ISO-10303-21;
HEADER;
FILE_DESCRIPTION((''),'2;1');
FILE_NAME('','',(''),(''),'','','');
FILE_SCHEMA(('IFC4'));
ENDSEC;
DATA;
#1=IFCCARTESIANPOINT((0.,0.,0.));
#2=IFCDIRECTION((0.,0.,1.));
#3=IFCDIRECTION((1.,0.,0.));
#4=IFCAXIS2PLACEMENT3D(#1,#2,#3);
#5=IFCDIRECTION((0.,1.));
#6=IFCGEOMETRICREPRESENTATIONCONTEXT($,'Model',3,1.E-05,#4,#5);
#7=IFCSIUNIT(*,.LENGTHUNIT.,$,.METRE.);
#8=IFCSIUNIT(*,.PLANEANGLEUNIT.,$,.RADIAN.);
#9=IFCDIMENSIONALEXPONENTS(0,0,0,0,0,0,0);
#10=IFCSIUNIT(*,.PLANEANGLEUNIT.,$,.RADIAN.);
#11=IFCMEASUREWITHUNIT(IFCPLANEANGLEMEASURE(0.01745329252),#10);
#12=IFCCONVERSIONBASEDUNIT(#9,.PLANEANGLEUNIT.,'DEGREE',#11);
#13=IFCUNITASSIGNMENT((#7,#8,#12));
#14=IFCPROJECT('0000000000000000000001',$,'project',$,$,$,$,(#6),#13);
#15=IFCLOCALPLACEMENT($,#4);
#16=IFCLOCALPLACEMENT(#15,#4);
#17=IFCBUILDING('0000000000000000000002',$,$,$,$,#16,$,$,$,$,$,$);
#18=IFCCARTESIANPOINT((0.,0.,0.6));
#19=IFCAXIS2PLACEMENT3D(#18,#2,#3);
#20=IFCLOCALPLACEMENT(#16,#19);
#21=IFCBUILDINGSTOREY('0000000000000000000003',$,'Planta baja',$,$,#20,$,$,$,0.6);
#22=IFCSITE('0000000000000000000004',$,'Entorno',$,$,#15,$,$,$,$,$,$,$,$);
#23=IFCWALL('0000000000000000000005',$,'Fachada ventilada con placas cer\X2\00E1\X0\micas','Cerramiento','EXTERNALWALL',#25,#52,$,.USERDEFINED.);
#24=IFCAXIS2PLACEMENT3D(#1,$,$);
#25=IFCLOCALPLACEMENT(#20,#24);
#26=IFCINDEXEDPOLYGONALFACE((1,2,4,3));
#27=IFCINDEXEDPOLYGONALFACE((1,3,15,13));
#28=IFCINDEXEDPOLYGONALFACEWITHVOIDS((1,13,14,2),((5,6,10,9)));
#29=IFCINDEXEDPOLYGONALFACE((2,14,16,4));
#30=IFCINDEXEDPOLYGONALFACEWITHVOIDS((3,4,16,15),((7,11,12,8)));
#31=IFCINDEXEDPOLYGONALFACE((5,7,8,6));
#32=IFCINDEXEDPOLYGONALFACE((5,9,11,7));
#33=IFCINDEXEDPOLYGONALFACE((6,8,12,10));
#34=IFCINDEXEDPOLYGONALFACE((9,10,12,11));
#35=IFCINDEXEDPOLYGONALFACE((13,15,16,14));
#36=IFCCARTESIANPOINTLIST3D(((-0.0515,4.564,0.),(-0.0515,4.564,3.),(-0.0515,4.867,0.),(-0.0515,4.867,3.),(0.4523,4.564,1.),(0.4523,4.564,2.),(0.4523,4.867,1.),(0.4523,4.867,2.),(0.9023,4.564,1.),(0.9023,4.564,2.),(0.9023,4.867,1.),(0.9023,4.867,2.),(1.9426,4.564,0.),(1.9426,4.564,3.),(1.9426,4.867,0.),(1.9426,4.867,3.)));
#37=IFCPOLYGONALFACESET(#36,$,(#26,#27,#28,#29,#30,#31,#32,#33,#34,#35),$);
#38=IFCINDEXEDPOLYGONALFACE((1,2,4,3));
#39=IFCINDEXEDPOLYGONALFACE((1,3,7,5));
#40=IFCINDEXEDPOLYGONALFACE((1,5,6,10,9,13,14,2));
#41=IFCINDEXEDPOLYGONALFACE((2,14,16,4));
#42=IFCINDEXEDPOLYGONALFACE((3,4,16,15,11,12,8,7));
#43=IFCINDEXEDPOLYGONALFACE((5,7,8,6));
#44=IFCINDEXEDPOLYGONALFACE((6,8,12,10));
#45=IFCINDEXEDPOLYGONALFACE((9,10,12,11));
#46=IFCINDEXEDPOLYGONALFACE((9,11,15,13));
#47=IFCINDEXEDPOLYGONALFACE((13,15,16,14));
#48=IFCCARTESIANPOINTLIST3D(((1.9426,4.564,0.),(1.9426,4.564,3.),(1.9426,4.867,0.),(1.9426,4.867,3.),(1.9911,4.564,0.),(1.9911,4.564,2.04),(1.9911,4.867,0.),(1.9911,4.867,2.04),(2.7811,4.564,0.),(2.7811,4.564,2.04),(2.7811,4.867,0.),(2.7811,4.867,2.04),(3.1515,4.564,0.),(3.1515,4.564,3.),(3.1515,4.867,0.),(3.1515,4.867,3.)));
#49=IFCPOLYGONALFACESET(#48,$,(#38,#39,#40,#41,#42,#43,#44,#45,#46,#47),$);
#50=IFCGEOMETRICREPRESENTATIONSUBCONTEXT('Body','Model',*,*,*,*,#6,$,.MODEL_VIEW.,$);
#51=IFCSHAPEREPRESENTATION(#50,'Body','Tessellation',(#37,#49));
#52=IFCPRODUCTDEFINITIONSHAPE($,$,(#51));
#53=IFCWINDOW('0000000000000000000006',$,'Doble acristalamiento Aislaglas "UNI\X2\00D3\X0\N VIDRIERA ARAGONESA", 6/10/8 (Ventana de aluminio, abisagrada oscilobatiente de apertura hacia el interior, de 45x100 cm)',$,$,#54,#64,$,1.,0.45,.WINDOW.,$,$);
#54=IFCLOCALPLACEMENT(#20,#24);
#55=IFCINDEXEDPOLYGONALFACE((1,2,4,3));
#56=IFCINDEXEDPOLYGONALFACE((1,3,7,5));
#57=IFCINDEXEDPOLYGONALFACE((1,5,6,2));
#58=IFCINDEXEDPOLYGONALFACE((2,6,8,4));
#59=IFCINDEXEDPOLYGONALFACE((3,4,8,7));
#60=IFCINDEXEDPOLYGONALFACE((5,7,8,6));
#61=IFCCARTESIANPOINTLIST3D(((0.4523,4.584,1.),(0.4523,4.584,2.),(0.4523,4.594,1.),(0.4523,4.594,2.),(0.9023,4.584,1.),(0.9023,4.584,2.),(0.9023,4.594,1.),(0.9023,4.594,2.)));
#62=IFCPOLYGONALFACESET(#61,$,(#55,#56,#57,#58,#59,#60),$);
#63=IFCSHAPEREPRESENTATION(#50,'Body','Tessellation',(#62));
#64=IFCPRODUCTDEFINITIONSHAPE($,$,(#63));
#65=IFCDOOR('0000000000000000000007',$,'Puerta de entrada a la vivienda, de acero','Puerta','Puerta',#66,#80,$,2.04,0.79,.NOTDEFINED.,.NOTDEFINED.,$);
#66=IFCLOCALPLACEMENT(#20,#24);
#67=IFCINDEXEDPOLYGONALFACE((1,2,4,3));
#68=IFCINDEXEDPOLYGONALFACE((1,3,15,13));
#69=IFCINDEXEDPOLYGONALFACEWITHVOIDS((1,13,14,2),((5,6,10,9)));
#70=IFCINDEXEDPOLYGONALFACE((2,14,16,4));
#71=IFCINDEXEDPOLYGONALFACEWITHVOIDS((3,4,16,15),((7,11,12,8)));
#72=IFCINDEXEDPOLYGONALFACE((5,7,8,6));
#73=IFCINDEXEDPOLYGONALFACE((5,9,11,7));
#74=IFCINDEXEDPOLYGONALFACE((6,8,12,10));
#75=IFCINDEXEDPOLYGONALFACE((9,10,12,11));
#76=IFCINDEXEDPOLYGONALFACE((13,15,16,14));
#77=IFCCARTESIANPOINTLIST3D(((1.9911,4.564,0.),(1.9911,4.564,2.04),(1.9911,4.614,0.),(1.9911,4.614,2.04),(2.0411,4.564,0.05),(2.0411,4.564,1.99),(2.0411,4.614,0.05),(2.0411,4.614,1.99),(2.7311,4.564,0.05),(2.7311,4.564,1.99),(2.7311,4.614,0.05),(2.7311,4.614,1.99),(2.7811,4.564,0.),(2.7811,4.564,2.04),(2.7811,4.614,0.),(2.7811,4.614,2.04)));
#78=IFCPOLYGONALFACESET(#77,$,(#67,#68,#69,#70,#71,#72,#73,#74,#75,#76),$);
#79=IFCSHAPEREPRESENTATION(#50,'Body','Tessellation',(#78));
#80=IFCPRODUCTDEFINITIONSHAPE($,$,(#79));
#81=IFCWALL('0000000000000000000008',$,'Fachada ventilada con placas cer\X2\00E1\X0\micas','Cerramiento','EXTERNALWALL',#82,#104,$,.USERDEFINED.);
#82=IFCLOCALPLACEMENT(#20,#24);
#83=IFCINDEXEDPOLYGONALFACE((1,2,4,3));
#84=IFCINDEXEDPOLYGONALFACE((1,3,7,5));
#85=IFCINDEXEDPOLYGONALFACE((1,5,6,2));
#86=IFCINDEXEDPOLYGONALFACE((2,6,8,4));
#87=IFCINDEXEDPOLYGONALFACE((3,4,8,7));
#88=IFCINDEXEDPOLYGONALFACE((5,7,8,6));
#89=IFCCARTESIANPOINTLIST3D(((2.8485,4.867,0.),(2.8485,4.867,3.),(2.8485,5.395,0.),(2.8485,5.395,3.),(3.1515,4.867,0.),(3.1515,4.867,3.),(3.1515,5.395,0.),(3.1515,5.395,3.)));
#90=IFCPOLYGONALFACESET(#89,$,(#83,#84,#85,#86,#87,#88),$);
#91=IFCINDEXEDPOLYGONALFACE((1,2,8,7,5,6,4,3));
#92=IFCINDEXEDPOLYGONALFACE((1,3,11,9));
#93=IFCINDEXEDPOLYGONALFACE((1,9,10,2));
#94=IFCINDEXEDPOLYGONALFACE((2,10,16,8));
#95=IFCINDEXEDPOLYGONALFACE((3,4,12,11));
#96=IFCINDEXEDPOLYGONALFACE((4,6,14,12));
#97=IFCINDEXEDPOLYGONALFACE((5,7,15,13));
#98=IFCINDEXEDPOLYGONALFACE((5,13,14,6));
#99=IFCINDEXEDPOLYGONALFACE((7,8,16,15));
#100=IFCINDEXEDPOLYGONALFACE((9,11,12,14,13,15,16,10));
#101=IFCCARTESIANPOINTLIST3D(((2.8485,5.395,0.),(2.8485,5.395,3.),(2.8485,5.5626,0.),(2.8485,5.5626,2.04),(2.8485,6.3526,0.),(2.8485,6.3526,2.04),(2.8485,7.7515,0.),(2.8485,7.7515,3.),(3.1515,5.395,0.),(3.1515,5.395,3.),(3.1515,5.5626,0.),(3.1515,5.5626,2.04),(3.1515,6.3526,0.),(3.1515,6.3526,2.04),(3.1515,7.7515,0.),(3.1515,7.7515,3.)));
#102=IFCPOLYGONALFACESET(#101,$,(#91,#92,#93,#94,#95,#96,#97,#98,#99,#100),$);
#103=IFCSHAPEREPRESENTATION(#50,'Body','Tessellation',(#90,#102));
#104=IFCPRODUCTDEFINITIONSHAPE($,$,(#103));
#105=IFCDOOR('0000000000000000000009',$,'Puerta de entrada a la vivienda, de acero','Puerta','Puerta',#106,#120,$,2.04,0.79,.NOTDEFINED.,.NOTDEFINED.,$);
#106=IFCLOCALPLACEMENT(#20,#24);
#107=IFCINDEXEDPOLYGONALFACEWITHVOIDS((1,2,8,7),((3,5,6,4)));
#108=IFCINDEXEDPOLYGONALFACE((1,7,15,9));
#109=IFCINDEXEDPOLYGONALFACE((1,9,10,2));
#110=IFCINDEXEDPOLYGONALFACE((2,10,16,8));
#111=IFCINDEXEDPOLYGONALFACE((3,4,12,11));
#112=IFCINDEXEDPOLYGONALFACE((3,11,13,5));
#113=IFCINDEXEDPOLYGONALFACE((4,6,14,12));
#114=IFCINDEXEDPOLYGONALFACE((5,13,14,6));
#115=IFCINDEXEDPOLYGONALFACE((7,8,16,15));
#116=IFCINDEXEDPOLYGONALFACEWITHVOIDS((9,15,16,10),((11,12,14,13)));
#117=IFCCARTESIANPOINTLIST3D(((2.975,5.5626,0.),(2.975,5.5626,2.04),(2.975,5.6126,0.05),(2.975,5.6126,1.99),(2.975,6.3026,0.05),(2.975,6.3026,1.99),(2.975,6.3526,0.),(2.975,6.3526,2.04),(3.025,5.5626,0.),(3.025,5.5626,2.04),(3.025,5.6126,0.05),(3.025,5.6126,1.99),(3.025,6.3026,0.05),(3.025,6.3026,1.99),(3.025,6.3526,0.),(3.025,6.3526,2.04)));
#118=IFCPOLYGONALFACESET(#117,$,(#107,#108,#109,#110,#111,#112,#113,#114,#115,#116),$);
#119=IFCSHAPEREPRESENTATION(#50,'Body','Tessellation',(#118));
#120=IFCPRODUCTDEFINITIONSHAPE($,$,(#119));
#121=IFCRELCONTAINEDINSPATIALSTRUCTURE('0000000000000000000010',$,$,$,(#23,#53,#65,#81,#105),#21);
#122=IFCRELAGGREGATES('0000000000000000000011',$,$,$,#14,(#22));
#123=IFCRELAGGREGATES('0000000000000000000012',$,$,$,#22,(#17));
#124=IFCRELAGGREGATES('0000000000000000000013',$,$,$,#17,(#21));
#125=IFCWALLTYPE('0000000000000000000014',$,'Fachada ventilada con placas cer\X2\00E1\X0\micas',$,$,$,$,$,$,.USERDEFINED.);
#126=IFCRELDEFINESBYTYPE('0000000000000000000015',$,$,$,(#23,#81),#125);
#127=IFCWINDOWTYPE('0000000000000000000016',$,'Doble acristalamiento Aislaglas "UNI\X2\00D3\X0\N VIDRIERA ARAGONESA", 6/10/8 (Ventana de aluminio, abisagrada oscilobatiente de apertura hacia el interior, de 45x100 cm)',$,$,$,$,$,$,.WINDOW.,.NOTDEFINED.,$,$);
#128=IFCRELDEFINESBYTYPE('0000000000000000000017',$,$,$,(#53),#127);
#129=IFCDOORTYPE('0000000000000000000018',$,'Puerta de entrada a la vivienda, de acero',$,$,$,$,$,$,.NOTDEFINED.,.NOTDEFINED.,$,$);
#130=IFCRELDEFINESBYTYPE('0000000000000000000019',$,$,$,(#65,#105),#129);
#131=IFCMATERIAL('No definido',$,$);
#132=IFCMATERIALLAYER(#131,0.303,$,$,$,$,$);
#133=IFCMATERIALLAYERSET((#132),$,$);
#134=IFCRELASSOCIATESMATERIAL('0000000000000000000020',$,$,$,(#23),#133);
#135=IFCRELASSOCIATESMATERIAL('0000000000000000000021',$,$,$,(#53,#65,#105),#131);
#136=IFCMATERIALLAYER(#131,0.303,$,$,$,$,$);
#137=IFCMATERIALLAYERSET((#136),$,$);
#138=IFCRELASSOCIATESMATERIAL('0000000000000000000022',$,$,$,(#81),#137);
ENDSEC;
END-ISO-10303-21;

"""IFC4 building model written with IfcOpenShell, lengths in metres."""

from ifc_helpers import new_model, entity, si_unit, converted_unit, direction, frame, origin_with_axes, origin_2d_with_axis, place, context, subcontext, project, spatial, rectangle, hollow_rectangle, extrude, shape, material, layer, layer_set, layer_usage, type_object, element, fill, save


model = new_model("IFC4")

# Units and contexts
model_context = context("Model", 3, precision=1e-05, world=origin_with_axes(), true_north=direction((0.0, 1.0)))
body_context = subcontext(model_context, "Body", "Model", "MODEL_VIEW")
footprint_context = subcontext(model_context, "FootPrint", "Model", "MODEL_VIEW")
ifc_project = project(units=[si_unit("LENGTHUNIT", "METRE"), si_unit("PLANEANGLEUNIT", "RADIAN"), converted_unit("PLANEANGLEUNIT", "DEGREE", entity("IfcPlaneAngleMeasure", 0.01745329252), si_unit("PLANEANGLEUNIT", "RADIAN"), dimensions=[0, 0, 0, 0, 0, 0, 0])], contexts=[model_context])

# Site, building, storey
site_placement = place(None, origin_with_axes())
site = spatial("IfcSite", under=ifc_project, at=site_placement, Name="Entorno")
building_placement = place(site_placement, origin_with_axes())
building = spatial("IfcBuilding", under=site, at=building_placement)
storey_placement = place(building_placement, frame((0.0, 0.0, 0.6), z_axis=(0.0, 0.0, 1.0), x_axis=(1.0, 0.0, 0.0)))
storey = spatial("IfcBuildingStorey", under=building, at=storey_placement, Name="Planta baja", Elevation=0.6)

# Shared definitions
ifc_material = material(Name="No definido")

# Shared definitions
wall_type_1 = type_object("IfcWallType", Name="Fachada ventilada con placas cerámicas", PredefinedType="USERDEFINED")

# Wall, openings, window, door
ifc_layer_1 = layer(ifc_material, 0.303)
ifc_layer_set_1 = layer_set([ifc_layer_1])
ifc_layer_usage_1 = layer_usage(ifc_layer_set_1, "AXIS2", "POSITIVE", -0.1515)
wall_1_placement = place(storey_placement, frame((0.1, 4.7155, 0.0), z_axis=(0.0, 0.0, 1.0), x_axis=(1.0, 0.0, 0.0)))
cartesian_point_1 = entity("IfcCartesianPoint", [-0.997, -1.5])
cartesian_point_2 = entity("IfcCartesianPoint", [-0.997, -1.5])
cartesian_point_3 = entity("IfcCartesianPoint", [-0.6045, -1.5])
cartesian_point_4 = entity("IfcCartesianPoint", [-0.6045, -1.5])
wall_1 = element("IfcWall", 1, at=wall_1_placement, inside=storey, type_object=wall_type_1, material=ifc_layer_usage_1, Name="Fachada ventilada con placas cerámicas", Description="Cerramiento", ObjectType="EXTERNALWALL", PredefinedType="USERDEFINED", context=body_context, shape_type="SolidModel", body=[
    entity("IfcExtrudedAreaSolidTapered", entity("IfcArbitraryClosedProfileDef", "AREA", None, entity("IfcPolyline", [cartesian_point_1, entity("IfcCartesianPoint", [0.997, -1.5]), entity("IfcCartesianPoint", [0.997, 1.5]), entity("IfcCartesianPoint", [-0.997, 1.5]), cartesian_point_1])), entity("IfcAxis2Placement3D", entity("IfcCartesianPoint", [0.8456, 0.1515, 1.5]), entity("IfcDirection", [0.0, -1.0, 0.0]), entity("IfcDirection", [1.0, 0.0, 0.0])), entity("IfcDirection", [0.0, 0.0, 1.0]), 0.303, entity("IfcArbitraryClosedProfileDef", "AREA", None, entity("IfcPolyline", [cartesian_point_2, entity("IfcCartesianPoint", [0.997, -1.5]), entity("IfcCartesianPoint", [0.997, 1.5]), entity("IfcCartesianPoint", [-0.997, 1.5]), cartesian_point_2]))),
    entity("IfcExtrudedAreaSolidTapered", entity("IfcArbitraryClosedProfileDef", "AREA", None, entity("IfcPolyline", [cartesian_point_3, entity("IfcCartesianPoint", [0.6045, -1.5]), entity("IfcCartesianPoint", [0.6045, 1.5]), entity("IfcCartesianPoint", [-0.6045, 1.5]), cartesian_point_3])), entity("IfcAxis2Placement3D", entity("IfcCartesianPoint", [2.447, 0.1515, 1.5]), entity("IfcDirection", [0.0, -1.0, 0.0]), entity("IfcDirection", [1.0, 0.0, 0.0])), entity("IfcDirection", [0.0, 0.0, 1.0]), 0.303, entity("IfcArbitraryClosedProfileDef", "AREA", None, entity("IfcPolyline", [cartesian_point_4, entity("IfcCartesianPoint", [0.6045, -1.5]), entity("IfcCartesianPoint", [0.6045, 1.5]), entity("IfcCartesianPoint", [-0.6045, 1.5]), cartesian_point_4]))),
])
opening_1_placement = place(wall_1_placement, frame((0.5773, 0.0, 1.5), z_axis=(0.0, 0.0, 1.0), x_axis=(1.0, 0.0, 0.0)))
cartesian_point_5 = entity("IfcCartesianPoint", [-0.225, -0.1515])
opening_1 = element("IfcOpeningElement", 2, at=opening_1_placement, cuts=wall_1, ObjectType="No definido", PredefinedType="OPENING", shapes=[
    shape(body_context, "Body", "SweptSolid", [extrude(rectangle(XDim=1.0, YDim=0.45, at=origin_2d_with_axis()), frame((0.0, -0.1515, 0.0), z_axis=(0.0, 1.0, 0.0), x_axis=(0.0, 0.0, 1.0)), (0.0, 0.0, 1.0), 0.303)]),
    shape(footprint_context, "FootPrint", "GeometricCurveSet", [entity("IfcGeometricCurveSet", [entity("IfcPolyline", [cartesian_point_5, entity("IfcCartesianPoint", [0.225, -0.1515]), entity("IfcCartesianPoint", [0.225, 0.1515]), entity("IfcCartesianPoint", [-0.225, 0.1515]), cartesian_point_5])])]),
])
opening_2_placement = place(wall_1_placement, frame((2.2861, 0.0, 1.02), z_axis=(0.0, 0.0, 1.0), x_axis=(1.0, 0.0, 0.0)))
cartesian_point_6 = entity("IfcCartesianPoint", [-0.395, -0.1515])
opening_2 = element("IfcOpeningElement", 3, at=opening_2_placement, cuts=wall_1, ObjectType="No definido", PredefinedType="OPENING", shapes=[
    shape(body_context, "Body", "SweptSolid", [extrude(rectangle(XDim=2.04, YDim=0.79, at=origin_2d_with_axis()), frame((0.0, -0.1515, 0.0), z_axis=(0.0, 1.0, 0.0), x_axis=(0.0, 0.0, 1.0)), (0.0, 0.0, 1.0), 0.303)]),
    shape(footprint_context, "FootPrint", "GeometricCurveSet", [entity("IfcGeometricCurveSet", [entity("IfcPolyline", [cartesian_point_6, entity("IfcCartesianPoint", [0.395, -0.1515]), entity("IfcCartesianPoint", [0.395, 0.1515]), entity("IfcCartesianPoint", [-0.395, 0.1515]), cartesian_point_6])])]),
])
window_type_1 = type_object("IfcWindowType", Name="Doble acristalamiento Aislaglas \"UNIÓN VIDRIERA ARAGONESA\", 6/10/8 (Ventana de aluminio, abisagrada oscilobatiente de apertura hacia el interior, de 45x100 cm)", PartitioningType="NOTDEFINED", PredefinedType="WINDOW")
window_1_placement = place(opening_1_placement, frame((0.0, -0.1265, 0.0), z_axis=(0.0, 0.0, 1.0), x_axis=(1.0, 0.0, 0.0)))
window_1 = element("IfcWindow", 4, at=window_1_placement, inside=storey, type_object=window_type_1, material=ifc_material, Name="Doble acristalamiento Aislaglas \"UNIÓN VIDRIERA ARAGONESA\", 6/10/8 (Ventana de aluminio, abisagrada oscilobatiente de apertura hacia el interior, de 45x100 cm)", OverallHeight=1.0, OverallWidth=0.45, PredefinedType="WINDOW", context=body_context, shape_type="SweptSolid", body=[
    extrude(rectangle(XDim=0.45, YDim=1.0, at=origin_2d_with_axis()), frame((0.0, 0.005, 0.0), z_axis=(0.0, -1.0, 0.0), x_axis=(1.0, 0.0, 0.0)), (0.0, 0.0, 1.0), 0.01),
])
fill(opening_1, window_1)
door_type_1 = type_object("IfcDoorType", Name="Puerta de entrada a la vivienda, de acero", OperationType="NOTDEFINED", PredefinedType="NOTDEFINED")
door_1_placement = place(opening_2_placement, frame((0.0, -0.1265, 0.0), z_axis=(0.0, 0.0, 1.0), x_axis=(1.0, 0.0, 0.0)))
door_1 = element("IfcDoor", 5, at=door_1_placement, inside=storey, type_object=door_type_1, material=ifc_material, Name="Puerta de entrada a la vivienda, de acero", Description="Puerta", ObjectType="Puerta", OperationType="NOTDEFINED", OverallHeight=2.04, OverallWidth=0.79, PredefinedType="NOTDEFINED", context=body_context, shape_type="SweptSolid", body=[
    extrude(hollow_rectangle(XDim=0.79, YDim=2.04, WallThickness=0.05, InnerFilletRadius=0.0, OuterFilletRadius=0.0, at=origin_2d_with_axis()), frame((0.0, 0.025, 0.0), z_axis=(0.0, -1.0, 0.0), x_axis=(1.0, 0.0, 0.0)), (0.0, 0.0, 1.0), 0.05),
])
fill(opening_2, door_1)

# Wall, opening, door
ifc_layer_2 = layer(ifc_material, 0.303)
ifc_layer_set_2 = layer_set([ifc_layer_2])
ifc_layer_usage_2 = layer_usage(ifc_layer_set_2, "AXIS2", "POSITIVE", -0.1515)
wall_2_placement = place(storey_placement, frame((3.0, 4.7155, 0.0), z_axis=(0.0, 0.0, 1.0), x_axis=(0.0, 1.0, 0.0)))
cartesian_point_7 = entity("IfcCartesianPoint", [-0.264, -1.5])
cartesian_point_8 = entity("IfcCartesianPoint", [-0.264, -1.5])
cartesian_point_9 = entity("IfcCartesianPoint", [-1.1783, -1.5])
cartesian_point_10 = entity("IfcCartesianPoint", [-1.1783, -1.5])
wall_2 = element("IfcWall", 6, at=wall_2_placement, inside=storey, type_object=wall_type_1, material=ifc_layer_usage_2, Name="Fachada ventilada con placas cerámicas", Description="Cerramiento", ObjectType="EXTERNALWALL", PredefinedType="USERDEFINED", context=body_context, shape_type="SolidModel", body=[
    entity("IfcExtrudedAreaSolidTapered", entity("IfcArbitraryClosedProfileDef", "AREA", None, entity("IfcPolyline", [cartesian_point_7, entity("IfcCartesianPoint", [0.264, -1.5]), entity("IfcCartesianPoint", [0.264, 1.5]), entity("IfcCartesianPoint", [-0.264, 1.5]), cartesian_point_7])), entity("IfcAxis2Placement3D", entity("IfcCartesianPoint", [0.4155, 0.1515, 1.5]), entity("IfcDirection", [0.0, -1.0, 0.0]), entity("IfcDirection", [1.0, 0.0, 0.0])), entity("IfcDirection", [0.0, 0.0, 1.0]), 0.303, entity("IfcArbitraryClosedProfileDef", "AREA", None, entity("IfcPolyline", [cartesian_point_8, entity("IfcCartesianPoint", [0.264, -1.5]), entity("IfcCartesianPoint", [0.264, 1.5]), entity("IfcCartesianPoint", [-0.264, 1.5]), cartesian_point_8]))),
    entity("IfcExtrudedAreaSolidTapered", entity("IfcArbitraryClosedProfileDef", "AREA", None, entity("IfcPolyline", [cartesian_point_9, entity("IfcCartesianPoint", [1.1783, -1.5]), entity("IfcCartesianPoint", [1.1783, 1.5]), entity("IfcCartesianPoint", [-1.1783, 1.5]), cartesian_point_9])), entity("IfcAxis2Placement3D", entity("IfcCartesianPoint", [1.8578, 0.1515, 1.5]), entity("IfcDirection", [0.0, -1.0, 0.0]), entity("IfcDirection", [1.0, 0.0, 0.0])), entity("IfcDirection", [0.0, 0.0, 1.0]), 0.303, entity("IfcArbitraryClosedProfileDef", "AREA", None, entity("IfcPolyline", [cartesian_point_10, entity("IfcCartesianPoint", [1.1783, -1.5]), entity("IfcCartesianPoint", [1.1783, 1.5]), entity("IfcCartesianPoint", [-1.1783, 1.5]), cartesian_point_10]))),
])
opening_3_placement = place(wall_2_placement, frame((1.2421, 0.0, 1.02), z_axis=(0.0, 0.0, 1.0), x_axis=(1.0, 0.0, 0.0)))
cartesian_point_11 = entity("IfcCartesianPoint", [-0.395, -0.1515])
opening_3 = element("IfcOpeningElement", 7, at=opening_3_placement, cuts=wall_2, ObjectType="No definido", PredefinedType="OPENING", shapes=[
    shape(body_context, "Body", "SweptSolid", [extrude(rectangle(XDim=2.04, YDim=0.79, at=origin_2d_with_axis()), frame((0.0, -0.1515, 0.0), z_axis=(0.0, 1.0, 0.0), x_axis=(0.0, 0.0, 1.0)), (0.0, 0.0, 1.0), 0.303)]),
    shape(footprint_context, "FootPrint", "GeometricCurveSet", [entity("IfcGeometricCurveSet", [entity("IfcPolyline", [cartesian_point_11, entity("IfcCartesianPoint", [0.395, -0.1515]), entity("IfcCartesianPoint", [0.395, 0.1515]), entity("IfcCartesianPoint", [-0.395, 0.1515]), cartesian_point_11])])]),
])
door_2_placement = place(opening_3_placement, origin_with_axes())
door_2 = element("IfcDoor", 8, at=door_2_placement, inside=storey, type_object=door_type_1, material=ifc_material, Name="Puerta de entrada a la vivienda, de acero", Description="Puerta", ObjectType="Puerta", OperationType="NOTDEFINED", OverallHeight=2.04, OverallWidth=0.79, PredefinedType="NOTDEFINED", context=body_context, shape_type="SweptSolid", body=[
    extrude(hollow_rectangle(XDim=0.79, YDim=2.04, WallThickness=0.05, InnerFilletRadius=0.0, OuterFilletRadius=0.0, at=origin_2d_with_axis()), frame((0.0, 0.025, 0.0), z_axis=(0.0, -1.0, 0.0), x_axis=(1.0, 0.0, 0.0)), (0.0, 0.0, 1.0), 0.05),
])
fill(opening_3, door_2)

save(model, "model.ifc")
